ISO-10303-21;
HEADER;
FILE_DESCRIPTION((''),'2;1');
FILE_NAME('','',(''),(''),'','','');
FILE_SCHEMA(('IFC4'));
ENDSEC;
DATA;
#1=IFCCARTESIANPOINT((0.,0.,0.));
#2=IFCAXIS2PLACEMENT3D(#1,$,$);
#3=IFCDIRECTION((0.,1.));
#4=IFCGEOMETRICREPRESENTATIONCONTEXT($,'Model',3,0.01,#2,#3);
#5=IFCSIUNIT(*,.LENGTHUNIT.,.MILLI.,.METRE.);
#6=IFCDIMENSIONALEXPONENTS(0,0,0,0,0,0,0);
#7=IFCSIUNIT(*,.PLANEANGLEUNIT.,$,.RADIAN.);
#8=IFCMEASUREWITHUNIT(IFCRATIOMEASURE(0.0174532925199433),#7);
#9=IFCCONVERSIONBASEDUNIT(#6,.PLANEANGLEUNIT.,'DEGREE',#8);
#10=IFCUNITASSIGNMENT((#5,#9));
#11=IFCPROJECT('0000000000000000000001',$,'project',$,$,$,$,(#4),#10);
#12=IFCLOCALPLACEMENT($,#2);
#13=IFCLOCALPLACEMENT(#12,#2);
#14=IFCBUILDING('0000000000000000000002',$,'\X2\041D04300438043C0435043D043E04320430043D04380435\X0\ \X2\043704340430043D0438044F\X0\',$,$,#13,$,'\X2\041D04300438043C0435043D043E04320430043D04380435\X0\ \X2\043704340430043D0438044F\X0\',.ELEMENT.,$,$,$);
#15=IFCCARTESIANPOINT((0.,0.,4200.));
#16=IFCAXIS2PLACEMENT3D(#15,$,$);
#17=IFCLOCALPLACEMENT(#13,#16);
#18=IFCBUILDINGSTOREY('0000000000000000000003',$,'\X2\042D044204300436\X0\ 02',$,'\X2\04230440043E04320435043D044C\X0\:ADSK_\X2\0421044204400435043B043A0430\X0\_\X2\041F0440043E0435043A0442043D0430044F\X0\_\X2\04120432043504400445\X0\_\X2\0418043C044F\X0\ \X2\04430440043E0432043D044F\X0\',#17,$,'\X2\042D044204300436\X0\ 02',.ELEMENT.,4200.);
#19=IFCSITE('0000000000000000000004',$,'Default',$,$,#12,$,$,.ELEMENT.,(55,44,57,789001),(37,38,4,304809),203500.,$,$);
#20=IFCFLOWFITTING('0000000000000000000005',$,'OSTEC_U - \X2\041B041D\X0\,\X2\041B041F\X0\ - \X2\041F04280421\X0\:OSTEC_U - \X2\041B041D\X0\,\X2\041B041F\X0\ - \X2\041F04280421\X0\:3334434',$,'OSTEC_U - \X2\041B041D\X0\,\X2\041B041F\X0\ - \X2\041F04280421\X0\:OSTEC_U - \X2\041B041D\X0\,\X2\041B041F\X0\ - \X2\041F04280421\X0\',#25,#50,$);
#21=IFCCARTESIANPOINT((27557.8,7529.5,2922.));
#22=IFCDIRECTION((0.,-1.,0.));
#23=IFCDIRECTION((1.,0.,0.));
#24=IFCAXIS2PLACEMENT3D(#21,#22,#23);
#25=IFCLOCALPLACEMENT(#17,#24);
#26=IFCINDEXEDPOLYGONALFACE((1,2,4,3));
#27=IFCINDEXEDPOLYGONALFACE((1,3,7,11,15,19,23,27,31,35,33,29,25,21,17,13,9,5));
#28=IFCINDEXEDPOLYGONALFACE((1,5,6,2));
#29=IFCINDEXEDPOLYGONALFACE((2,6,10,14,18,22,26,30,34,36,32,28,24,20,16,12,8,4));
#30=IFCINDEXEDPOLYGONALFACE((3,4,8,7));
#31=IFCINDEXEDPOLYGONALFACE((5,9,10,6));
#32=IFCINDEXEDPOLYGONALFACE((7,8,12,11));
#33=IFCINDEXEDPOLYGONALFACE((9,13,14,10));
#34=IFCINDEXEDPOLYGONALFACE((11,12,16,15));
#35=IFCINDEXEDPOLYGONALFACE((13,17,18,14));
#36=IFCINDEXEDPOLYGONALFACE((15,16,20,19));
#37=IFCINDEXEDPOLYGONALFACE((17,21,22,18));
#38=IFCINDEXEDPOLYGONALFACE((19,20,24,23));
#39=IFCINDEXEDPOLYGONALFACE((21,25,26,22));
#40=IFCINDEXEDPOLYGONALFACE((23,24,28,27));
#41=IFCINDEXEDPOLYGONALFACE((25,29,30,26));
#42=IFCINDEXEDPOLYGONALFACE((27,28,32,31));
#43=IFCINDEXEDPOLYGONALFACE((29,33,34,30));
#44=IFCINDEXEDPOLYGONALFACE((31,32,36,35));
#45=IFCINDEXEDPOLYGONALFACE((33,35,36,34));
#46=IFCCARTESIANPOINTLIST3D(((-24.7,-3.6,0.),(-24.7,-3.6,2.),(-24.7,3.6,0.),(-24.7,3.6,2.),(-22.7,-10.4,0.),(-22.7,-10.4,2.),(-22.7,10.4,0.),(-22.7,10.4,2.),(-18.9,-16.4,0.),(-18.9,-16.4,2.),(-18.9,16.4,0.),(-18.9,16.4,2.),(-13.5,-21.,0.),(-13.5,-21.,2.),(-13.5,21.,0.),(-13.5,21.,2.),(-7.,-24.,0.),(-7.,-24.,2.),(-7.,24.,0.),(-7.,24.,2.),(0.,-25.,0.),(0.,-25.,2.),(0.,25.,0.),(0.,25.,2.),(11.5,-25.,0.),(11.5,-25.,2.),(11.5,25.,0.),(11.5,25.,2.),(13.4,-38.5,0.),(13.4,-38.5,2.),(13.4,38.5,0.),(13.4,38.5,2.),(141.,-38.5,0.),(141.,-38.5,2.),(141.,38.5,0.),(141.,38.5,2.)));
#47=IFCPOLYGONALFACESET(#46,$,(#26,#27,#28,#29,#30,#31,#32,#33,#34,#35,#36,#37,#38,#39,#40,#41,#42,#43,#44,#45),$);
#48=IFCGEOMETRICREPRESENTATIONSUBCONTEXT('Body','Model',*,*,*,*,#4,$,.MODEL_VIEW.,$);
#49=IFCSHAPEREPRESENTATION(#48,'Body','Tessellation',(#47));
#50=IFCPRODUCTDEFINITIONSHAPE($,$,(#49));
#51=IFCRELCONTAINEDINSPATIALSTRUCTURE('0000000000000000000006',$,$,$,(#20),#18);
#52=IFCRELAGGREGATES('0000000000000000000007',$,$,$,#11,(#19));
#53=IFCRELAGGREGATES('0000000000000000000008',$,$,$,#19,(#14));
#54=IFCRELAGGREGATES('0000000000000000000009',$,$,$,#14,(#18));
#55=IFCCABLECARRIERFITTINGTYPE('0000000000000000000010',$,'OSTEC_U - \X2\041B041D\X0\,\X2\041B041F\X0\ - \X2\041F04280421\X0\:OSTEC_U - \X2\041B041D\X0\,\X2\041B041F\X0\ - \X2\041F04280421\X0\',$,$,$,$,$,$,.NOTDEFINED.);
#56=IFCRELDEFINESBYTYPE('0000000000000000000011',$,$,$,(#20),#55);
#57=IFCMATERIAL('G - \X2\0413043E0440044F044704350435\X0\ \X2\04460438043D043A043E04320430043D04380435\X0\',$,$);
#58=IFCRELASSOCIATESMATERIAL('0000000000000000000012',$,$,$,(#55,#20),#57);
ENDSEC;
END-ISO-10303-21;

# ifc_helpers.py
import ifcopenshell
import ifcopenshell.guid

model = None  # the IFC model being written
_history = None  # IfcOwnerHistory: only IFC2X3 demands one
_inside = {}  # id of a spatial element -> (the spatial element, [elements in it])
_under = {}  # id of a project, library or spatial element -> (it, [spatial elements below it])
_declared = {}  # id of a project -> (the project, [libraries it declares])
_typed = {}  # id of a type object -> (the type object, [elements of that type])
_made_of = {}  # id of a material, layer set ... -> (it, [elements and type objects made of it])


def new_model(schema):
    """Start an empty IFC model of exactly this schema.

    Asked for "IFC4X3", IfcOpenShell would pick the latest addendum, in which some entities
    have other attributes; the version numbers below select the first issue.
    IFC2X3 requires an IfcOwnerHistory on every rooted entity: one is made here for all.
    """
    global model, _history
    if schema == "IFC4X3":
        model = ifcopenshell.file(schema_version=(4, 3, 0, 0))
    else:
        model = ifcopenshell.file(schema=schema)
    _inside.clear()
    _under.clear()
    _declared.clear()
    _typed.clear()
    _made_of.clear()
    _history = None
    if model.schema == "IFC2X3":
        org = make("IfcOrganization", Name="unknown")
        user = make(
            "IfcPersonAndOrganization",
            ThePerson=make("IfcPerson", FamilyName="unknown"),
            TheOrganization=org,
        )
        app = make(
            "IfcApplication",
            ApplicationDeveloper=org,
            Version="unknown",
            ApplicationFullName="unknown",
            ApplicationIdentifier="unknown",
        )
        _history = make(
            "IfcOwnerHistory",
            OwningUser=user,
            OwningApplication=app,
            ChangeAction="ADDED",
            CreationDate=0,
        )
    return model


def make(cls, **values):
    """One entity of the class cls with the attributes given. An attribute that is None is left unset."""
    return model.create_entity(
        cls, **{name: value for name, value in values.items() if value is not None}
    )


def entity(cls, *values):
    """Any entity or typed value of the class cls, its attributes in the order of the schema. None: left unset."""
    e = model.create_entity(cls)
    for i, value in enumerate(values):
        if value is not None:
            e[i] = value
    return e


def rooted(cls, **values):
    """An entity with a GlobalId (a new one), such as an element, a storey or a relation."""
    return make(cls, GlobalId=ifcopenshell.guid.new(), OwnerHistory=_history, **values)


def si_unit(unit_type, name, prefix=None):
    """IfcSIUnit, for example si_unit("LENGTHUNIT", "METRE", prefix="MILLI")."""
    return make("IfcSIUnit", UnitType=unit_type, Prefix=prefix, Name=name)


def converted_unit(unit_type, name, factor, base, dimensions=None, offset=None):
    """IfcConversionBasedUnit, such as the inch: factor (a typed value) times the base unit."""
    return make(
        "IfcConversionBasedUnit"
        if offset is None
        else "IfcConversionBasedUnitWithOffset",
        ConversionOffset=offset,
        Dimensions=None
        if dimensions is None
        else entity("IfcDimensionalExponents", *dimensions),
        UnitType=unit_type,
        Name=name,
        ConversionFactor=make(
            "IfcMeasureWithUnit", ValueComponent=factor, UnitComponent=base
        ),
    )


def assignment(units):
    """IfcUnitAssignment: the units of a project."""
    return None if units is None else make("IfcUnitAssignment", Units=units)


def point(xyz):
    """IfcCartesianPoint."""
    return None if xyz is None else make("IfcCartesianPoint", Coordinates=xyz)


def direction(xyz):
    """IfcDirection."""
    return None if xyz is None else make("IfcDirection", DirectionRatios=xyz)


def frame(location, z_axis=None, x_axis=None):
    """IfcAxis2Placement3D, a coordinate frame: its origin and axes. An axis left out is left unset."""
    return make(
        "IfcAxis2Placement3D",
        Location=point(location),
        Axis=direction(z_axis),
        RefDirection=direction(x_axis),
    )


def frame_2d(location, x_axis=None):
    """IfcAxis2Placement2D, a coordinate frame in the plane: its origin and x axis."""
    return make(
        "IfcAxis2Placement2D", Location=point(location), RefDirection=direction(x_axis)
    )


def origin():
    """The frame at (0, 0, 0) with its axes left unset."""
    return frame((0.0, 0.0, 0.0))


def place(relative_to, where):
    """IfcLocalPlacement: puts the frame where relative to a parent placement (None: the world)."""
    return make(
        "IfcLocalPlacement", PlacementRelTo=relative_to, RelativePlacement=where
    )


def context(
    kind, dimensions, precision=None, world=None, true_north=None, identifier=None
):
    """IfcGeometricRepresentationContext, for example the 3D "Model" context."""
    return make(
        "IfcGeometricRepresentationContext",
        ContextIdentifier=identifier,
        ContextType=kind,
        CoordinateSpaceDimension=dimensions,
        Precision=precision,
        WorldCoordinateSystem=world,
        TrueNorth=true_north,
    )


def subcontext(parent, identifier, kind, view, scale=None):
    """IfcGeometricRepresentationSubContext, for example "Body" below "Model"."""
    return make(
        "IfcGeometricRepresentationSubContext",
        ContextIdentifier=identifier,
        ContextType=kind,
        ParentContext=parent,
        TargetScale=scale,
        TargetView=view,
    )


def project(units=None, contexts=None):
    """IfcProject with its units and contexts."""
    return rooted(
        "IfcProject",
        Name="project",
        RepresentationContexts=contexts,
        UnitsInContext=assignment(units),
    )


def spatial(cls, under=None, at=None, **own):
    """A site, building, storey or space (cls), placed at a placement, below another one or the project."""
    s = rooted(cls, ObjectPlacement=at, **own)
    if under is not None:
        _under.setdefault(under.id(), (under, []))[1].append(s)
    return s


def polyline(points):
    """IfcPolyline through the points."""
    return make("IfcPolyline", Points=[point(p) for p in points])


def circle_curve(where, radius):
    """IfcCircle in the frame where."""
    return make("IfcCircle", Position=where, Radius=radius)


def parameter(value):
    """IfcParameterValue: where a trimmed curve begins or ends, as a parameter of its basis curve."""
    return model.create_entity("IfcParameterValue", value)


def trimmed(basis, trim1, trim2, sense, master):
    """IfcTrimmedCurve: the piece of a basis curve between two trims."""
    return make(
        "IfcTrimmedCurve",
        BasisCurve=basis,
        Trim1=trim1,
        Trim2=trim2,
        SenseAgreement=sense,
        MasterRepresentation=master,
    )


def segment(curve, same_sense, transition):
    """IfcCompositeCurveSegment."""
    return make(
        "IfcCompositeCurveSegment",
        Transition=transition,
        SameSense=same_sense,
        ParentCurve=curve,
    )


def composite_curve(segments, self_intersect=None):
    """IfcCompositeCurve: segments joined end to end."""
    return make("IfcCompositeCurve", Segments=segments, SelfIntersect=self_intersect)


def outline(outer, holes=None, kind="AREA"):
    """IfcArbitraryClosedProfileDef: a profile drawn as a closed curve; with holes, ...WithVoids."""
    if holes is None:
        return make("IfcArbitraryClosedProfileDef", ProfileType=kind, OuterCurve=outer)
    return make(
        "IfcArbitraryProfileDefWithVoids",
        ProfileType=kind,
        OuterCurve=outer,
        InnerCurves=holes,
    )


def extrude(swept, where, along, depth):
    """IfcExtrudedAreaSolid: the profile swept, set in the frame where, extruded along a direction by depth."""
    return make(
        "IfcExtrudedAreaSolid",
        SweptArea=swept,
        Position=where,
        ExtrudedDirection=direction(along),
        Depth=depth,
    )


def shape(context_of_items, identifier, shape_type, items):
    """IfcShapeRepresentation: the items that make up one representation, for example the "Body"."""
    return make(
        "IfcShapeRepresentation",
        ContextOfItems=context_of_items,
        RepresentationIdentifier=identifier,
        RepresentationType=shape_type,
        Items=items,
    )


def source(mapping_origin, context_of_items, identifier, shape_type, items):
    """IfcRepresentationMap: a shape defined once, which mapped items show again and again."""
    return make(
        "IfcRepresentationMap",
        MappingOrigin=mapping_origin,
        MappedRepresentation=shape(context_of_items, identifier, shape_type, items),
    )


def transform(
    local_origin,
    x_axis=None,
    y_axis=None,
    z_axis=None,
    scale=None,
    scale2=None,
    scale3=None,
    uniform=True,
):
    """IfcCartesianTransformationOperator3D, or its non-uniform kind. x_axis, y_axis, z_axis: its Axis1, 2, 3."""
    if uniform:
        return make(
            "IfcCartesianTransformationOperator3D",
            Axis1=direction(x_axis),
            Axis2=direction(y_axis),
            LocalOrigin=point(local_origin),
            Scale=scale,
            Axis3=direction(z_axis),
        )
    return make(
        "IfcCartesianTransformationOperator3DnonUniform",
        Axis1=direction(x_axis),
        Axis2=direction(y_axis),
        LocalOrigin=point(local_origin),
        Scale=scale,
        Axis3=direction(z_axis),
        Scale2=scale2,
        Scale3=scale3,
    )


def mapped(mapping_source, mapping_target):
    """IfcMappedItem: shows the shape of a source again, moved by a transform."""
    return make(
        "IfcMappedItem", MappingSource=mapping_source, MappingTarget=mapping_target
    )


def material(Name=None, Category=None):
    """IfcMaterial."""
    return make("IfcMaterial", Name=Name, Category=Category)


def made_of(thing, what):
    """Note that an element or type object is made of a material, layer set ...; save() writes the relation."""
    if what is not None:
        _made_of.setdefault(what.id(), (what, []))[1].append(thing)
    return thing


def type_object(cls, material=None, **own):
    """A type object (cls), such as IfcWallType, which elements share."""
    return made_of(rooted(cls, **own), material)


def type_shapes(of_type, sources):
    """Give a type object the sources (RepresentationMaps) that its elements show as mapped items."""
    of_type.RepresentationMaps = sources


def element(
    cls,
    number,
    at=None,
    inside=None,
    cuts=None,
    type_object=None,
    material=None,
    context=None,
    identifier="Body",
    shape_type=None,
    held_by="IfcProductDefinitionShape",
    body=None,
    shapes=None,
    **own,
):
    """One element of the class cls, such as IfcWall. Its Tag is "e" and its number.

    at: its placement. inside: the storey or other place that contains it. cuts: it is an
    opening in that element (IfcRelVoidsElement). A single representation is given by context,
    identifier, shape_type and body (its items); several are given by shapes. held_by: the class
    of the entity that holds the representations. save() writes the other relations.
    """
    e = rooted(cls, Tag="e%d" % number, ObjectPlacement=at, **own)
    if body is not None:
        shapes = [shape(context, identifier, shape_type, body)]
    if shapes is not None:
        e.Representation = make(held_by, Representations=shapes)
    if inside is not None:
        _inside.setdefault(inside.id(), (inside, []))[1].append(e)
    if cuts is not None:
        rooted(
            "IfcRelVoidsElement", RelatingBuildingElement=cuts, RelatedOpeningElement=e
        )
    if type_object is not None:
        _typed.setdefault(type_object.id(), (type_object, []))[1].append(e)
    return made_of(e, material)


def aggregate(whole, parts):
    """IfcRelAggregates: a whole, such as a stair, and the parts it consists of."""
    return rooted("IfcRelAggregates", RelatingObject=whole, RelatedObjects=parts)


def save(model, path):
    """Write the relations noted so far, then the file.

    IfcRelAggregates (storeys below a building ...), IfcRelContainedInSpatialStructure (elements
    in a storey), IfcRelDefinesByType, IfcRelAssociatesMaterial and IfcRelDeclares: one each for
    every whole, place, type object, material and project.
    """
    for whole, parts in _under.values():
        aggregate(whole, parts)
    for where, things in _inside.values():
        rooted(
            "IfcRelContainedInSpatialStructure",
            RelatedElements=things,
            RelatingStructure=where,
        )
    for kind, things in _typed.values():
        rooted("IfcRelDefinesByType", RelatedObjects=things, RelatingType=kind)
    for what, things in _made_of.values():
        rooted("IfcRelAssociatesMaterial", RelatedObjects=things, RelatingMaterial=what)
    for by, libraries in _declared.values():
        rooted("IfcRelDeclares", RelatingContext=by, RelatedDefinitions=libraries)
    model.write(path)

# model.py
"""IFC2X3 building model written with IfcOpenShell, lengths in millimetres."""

from ifc_helpers import new_model, entity, si_unit, converted_unit, direction, frame, frame_2d, origin, place, context, subcontext, project, spatial, polyline, circle_curve, parameter, trimmed, segment, composite_curve, outline, extrude, source, transform, mapped, material, type_object, type_shapes, element, save


model = new_model("IFC2X3")

# Units and contexts
model_context = context("Model", 3, precision=0.01, world=origin(), true_north=direction((0.0, 1.0)))
body_context = subcontext(model_context, "Body", "Model", "MODEL_VIEW")
ifc_project = project(units=[si_unit("LENGTHUNIT", "METRE", prefix="MILLI"), converted_unit("PLANEANGLEUNIT", "DEGREE", entity("IfcRatioMeasure", 0.0174532925199433), si_unit("PLANEANGLEUNIT", "RADIAN"), dimensions=[0, 0, 0, 0, 0, 0, 0])], contexts=[model_context])

# Site, building, storey
site_placement = place(None, origin())
site = spatial("IfcSite", under=ifc_project, at=site_placement, Name="Default", CompositionType="ELEMENT", RefLatitude=(55, 44, 57, 789001), RefLongitude=(37, 38, 4, 304809), RefElevation=203500.0)
building_placement = place(site_placement, origin())
building = spatial("IfcBuilding", under=site, at=building_placement, Name="Наименование здания", LongName="Наименование здания", CompositionType="ELEMENT")
storey_placement = place(building_placement, frame((0.0, 0.0, 4200.0)))
storey = spatial("IfcBuildingStorey", under=building, at=storey_placement, Name="Этаж 02", ObjectType="Уровень:ADSK_Стрелка_Проектная_Вверх_Имя уровня", LongName="Этаж 02", CompositionType="ELEMENT", Elevation=4200.0)

# Flow fitting
ifc_material_1 = material(Name="G - Горячее цинкование")
cable_carrier_fitting_type_1 = type_object("IfcCableCarrierFittingType", Name="OSTEC_U - ЛН,ЛП - ПШС:OSTEC_U - ЛН,ЛП - ПШС", PredefinedType="NOTDEFINED", material=ifc_material_1)
shared_shape_1 = source(origin(), body_context, "Body", "SweptSolid", [
    extrude(outline(composite_curve([segment(trimmed(circle_curve(frame_2d((-41.5, 0.0), x_axis=(1.0, 0.0)), 25.0), [parameter(90.0)], [parameter(270.0)], True, "PARAMETER"), True, "CONTINUOUS"), segment(polyline([(-41.5, -25.0), (-30.0, -25.0)]), True, "CONTINUOUS"), segment(polyline([(-30.0, -25.0), (-28.1, -38.5)]), True, "CONTINUOUS"), segment(polyline([(-28.1, -38.5), (99.5, -38.5)]), True, "CONTINUOUS"), segment(polyline([(99.5, -38.5), (99.5, 38.5)]), True, "CONTINUOUS"), segment(polyline([(99.5, 38.5), (-28.1, 38.5)]), True, "CONTINUOUS"), segment(polyline([(-28.1, 38.5), (-30.0, 25.0)]), True, "CONTINUOUS"), segment(polyline([(-30.0, 25.0), (-41.5, 25.0)]), True, "CONTINUOUS")], self_intersect=False)), frame((41.5, 0.0, 0.0), z_axis=(0.0, 0.0, -1.0), x_axis=(1.0, 0.0, 0.0)), (0.0, 0.0, -1.0), 2.0),
])
type_shapes(cable_carrier_fitting_type_1, [shared_shape_1])
flow_fitting_1_placement = place(storey_placement, frame((27557.8, 7529.5, 2922.0), z_axis=(0.0, -1.0, 0.0), x_axis=(1.0, 0.0, 0.0)))
element("IfcFlowFitting", 1, at=flow_fitting_1_placement, inside=storey, type_object=cable_carrier_fitting_type_1, material=ifc_material_1, Name="OSTEC_U - ЛН,ЛП - ПШС:OSTEC_U - ЛН,ЛП - ПШС:3334434", ObjectType="OSTEC_U - ЛН,ЛП - ПШС:OSTEC_U - ЛН,ЛП - ПШС", context=body_context, shape_type="MappedRepresentation", body=[
    mapped(shared_shape_1, transform((0.0, 0.0, 0.0), scale=1.0)),
])

save(model, "model.ifc")
